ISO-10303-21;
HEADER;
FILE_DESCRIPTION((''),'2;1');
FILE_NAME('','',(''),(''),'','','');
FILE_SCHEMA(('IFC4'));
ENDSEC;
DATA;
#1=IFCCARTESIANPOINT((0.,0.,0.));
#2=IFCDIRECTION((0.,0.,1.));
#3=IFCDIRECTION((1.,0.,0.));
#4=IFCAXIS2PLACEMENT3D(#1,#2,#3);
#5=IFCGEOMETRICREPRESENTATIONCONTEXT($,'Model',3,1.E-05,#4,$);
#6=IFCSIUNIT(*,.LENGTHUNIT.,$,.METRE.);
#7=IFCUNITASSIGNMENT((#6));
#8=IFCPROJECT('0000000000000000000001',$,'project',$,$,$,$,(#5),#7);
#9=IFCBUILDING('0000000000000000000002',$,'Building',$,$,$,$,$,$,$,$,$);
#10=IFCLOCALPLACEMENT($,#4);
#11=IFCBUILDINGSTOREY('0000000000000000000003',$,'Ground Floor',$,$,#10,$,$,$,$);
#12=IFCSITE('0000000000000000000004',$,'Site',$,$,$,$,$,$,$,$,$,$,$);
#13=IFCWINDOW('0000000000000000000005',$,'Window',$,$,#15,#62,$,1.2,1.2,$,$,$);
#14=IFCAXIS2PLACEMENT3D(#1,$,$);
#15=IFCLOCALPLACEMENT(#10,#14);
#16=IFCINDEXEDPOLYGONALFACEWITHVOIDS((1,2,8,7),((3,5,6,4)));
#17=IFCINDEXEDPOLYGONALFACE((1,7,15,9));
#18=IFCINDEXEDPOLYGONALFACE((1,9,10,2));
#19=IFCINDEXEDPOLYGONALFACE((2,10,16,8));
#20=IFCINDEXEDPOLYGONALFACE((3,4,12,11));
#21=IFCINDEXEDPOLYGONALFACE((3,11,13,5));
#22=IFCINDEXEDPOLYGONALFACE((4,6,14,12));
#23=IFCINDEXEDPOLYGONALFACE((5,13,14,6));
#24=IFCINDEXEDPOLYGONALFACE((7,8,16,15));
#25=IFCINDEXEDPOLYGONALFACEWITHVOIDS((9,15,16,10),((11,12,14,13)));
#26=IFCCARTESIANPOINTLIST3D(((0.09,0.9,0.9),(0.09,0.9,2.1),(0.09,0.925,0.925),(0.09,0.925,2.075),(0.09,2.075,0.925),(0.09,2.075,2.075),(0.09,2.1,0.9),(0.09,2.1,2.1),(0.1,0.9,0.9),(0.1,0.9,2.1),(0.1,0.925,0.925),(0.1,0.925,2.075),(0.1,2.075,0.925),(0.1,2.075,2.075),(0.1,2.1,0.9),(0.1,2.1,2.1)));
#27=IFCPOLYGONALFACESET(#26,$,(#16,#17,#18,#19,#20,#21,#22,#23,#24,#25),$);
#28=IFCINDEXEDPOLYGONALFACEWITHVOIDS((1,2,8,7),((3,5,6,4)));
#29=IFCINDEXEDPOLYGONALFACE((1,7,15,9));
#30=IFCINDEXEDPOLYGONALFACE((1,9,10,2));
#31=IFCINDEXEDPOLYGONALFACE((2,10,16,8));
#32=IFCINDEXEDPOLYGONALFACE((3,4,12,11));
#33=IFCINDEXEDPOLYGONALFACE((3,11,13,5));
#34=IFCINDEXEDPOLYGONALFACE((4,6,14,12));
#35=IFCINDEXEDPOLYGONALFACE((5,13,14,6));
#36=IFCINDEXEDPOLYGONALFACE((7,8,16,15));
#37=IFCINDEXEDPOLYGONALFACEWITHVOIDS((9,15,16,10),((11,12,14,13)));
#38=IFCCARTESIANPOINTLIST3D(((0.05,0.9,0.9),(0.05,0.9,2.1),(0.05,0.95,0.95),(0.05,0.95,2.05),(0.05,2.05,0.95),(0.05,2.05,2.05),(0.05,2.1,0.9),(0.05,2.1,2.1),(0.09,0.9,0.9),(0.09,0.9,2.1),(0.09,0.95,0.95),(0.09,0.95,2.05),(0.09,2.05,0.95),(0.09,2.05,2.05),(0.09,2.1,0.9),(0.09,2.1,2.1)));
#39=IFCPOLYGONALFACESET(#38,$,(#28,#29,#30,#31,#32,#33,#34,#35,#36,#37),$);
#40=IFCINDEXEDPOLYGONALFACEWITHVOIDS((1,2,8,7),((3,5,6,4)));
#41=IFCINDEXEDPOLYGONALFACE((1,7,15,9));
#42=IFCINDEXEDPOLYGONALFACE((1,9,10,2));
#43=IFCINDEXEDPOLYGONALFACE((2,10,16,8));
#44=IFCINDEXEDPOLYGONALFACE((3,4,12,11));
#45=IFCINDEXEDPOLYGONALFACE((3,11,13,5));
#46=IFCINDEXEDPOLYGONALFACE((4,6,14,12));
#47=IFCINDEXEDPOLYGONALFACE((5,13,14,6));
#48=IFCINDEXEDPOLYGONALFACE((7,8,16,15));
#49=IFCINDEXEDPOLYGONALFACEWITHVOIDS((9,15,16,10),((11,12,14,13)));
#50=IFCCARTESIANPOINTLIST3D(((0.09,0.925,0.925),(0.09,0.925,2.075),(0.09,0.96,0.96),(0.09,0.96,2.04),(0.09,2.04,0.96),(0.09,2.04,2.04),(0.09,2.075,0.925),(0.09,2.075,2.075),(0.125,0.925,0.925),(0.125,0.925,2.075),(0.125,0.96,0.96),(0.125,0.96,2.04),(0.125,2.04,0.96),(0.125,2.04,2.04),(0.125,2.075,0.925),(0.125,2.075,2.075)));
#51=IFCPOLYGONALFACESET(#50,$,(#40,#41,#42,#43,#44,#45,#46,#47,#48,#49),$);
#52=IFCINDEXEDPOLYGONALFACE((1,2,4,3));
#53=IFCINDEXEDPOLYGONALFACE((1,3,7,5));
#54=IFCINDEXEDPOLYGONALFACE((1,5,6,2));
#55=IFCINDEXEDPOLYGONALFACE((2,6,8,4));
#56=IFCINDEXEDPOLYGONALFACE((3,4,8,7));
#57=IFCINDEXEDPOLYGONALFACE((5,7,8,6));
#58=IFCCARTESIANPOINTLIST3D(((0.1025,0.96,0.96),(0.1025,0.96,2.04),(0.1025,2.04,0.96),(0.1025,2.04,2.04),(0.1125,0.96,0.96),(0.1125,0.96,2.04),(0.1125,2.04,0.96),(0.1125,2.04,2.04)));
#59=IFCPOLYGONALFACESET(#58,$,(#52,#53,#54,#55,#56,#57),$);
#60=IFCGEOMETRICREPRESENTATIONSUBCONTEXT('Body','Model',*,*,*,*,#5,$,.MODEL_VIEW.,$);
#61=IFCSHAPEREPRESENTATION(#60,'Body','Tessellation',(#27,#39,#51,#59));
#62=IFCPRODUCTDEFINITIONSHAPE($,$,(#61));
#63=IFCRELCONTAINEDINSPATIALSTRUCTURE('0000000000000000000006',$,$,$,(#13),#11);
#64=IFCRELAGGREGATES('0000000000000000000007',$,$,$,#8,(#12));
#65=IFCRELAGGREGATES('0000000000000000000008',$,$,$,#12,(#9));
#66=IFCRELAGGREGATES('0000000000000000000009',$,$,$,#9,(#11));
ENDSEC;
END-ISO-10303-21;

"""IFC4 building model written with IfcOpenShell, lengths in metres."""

from ifc_helpers import new_model, si_unit, frame, origin_with_axes, place, context, subcontext, project, spatial, line, indexed_curve, outline, extrude, element, save


model = new_model("IFC4")

# Units and contexts
model_context = context("Model", 3, precision=1e-05, world=origin_with_axes())
body_context = subcontext(model_context, "Body", "Model", "MODEL_VIEW")
ifc_project = project(units=[si_unit("LENGTHUNIT", "METRE")], contexts=[model_context])

# Site, building, storey
site = spatial("IfcSite", under=ifc_project, Name="Site")
building = spatial("IfcBuilding", under=site, Name="Building")
storey_placement = place(None, origin_with_axes())
storey = spatial("IfcBuildingStorey", under=building, at=storey_placement, Name="Ground Floor")

# Window
for number, where, z_axis, x_axis, name in (
    (1, (0.0, 2.1, 0.9), (0.0, 0.0, 1.0), (0.0, -1.0, 0.0), "Window"),
):
    element("IfcWindow", number, at=place(storey_placement, frame(where, z_axis=z_axis, x_axis=x_axis)), inside=storey, Name=name, OverallHeight=1.2, OverallWidth=1.2, context=body_context, shape_type="SweptSolid", body=[
        extrude(outline(indexed_curve([(0.0, 0.0), (1.2, 0.0), (1.2, 1.2), (0.0, 1.2)], segments=[line(1, 2, 3, 4, 1)]), holes=[indexed_curve([(0.025, 0.025), (1.175, 0.025), (1.175, 1.175), (0.025, 1.175)], segments=[line(1, 2, 3, 4, 1)])]), frame((0.0, 0.09, 0.0), z_axis=(0.0, -1.0, 0.0), x_axis=(1.0, 0.0, 0.0)), (0.0, 0.0, -1.0), 0.01),
        extrude(outline(indexed_curve([(0.0, 0.0), (1.2, 0.0), (1.2, 1.2), (0.0, 1.2)], segments=[line(1, 2, 3, 4, 1)]), holes=[indexed_curve([(0.05, 0.05), (1.15, 0.05), (1.15, 1.15), (0.05, 1.15)], segments=[line(1, 2, 3, 4, 1)])]), frame((0.0, 0.05, 0.0), z_axis=(0.0, -1.0, 0.0), x_axis=(1.0, 0.0, 0.0)), (0.0, 0.0, -1.0), 0.04),
        extrude(outline(indexed_curve([(0.0, 0.0), (1.15, 0.0), (1.15, 1.15), (0.0, 1.15)], segments=[line(1, 2, 3, 4, 1)]), holes=[indexed_curve([(0.035, 0.035), (1.115, 0.035), (1.115, 1.115), (0.035, 1.115)], segments=[line(1, 2, 3, 4, 1)])]), frame((0.025, 0.09, 0.025), z_axis=(0.0, -1.0, 0.0), x_axis=(1.0, 0.0, 0.0)), (0.0, 0.0, -1.0), 0.035),
        extrude(outline(indexed_curve([(0.035, 0.035), (1.115, 0.035), (1.115, 1.115), (0.035, 1.115)], segments=[line(1, 2, 3, 4, 1)])), frame((0.025, 0.1025, 0.025), z_axis=(0.0, -1.0, 0.0), x_axis=(1.0, 0.0, 0.0)), (0.0, 0.0, -1.0), 0.01),
    ])

save(model, "model.ifc")
